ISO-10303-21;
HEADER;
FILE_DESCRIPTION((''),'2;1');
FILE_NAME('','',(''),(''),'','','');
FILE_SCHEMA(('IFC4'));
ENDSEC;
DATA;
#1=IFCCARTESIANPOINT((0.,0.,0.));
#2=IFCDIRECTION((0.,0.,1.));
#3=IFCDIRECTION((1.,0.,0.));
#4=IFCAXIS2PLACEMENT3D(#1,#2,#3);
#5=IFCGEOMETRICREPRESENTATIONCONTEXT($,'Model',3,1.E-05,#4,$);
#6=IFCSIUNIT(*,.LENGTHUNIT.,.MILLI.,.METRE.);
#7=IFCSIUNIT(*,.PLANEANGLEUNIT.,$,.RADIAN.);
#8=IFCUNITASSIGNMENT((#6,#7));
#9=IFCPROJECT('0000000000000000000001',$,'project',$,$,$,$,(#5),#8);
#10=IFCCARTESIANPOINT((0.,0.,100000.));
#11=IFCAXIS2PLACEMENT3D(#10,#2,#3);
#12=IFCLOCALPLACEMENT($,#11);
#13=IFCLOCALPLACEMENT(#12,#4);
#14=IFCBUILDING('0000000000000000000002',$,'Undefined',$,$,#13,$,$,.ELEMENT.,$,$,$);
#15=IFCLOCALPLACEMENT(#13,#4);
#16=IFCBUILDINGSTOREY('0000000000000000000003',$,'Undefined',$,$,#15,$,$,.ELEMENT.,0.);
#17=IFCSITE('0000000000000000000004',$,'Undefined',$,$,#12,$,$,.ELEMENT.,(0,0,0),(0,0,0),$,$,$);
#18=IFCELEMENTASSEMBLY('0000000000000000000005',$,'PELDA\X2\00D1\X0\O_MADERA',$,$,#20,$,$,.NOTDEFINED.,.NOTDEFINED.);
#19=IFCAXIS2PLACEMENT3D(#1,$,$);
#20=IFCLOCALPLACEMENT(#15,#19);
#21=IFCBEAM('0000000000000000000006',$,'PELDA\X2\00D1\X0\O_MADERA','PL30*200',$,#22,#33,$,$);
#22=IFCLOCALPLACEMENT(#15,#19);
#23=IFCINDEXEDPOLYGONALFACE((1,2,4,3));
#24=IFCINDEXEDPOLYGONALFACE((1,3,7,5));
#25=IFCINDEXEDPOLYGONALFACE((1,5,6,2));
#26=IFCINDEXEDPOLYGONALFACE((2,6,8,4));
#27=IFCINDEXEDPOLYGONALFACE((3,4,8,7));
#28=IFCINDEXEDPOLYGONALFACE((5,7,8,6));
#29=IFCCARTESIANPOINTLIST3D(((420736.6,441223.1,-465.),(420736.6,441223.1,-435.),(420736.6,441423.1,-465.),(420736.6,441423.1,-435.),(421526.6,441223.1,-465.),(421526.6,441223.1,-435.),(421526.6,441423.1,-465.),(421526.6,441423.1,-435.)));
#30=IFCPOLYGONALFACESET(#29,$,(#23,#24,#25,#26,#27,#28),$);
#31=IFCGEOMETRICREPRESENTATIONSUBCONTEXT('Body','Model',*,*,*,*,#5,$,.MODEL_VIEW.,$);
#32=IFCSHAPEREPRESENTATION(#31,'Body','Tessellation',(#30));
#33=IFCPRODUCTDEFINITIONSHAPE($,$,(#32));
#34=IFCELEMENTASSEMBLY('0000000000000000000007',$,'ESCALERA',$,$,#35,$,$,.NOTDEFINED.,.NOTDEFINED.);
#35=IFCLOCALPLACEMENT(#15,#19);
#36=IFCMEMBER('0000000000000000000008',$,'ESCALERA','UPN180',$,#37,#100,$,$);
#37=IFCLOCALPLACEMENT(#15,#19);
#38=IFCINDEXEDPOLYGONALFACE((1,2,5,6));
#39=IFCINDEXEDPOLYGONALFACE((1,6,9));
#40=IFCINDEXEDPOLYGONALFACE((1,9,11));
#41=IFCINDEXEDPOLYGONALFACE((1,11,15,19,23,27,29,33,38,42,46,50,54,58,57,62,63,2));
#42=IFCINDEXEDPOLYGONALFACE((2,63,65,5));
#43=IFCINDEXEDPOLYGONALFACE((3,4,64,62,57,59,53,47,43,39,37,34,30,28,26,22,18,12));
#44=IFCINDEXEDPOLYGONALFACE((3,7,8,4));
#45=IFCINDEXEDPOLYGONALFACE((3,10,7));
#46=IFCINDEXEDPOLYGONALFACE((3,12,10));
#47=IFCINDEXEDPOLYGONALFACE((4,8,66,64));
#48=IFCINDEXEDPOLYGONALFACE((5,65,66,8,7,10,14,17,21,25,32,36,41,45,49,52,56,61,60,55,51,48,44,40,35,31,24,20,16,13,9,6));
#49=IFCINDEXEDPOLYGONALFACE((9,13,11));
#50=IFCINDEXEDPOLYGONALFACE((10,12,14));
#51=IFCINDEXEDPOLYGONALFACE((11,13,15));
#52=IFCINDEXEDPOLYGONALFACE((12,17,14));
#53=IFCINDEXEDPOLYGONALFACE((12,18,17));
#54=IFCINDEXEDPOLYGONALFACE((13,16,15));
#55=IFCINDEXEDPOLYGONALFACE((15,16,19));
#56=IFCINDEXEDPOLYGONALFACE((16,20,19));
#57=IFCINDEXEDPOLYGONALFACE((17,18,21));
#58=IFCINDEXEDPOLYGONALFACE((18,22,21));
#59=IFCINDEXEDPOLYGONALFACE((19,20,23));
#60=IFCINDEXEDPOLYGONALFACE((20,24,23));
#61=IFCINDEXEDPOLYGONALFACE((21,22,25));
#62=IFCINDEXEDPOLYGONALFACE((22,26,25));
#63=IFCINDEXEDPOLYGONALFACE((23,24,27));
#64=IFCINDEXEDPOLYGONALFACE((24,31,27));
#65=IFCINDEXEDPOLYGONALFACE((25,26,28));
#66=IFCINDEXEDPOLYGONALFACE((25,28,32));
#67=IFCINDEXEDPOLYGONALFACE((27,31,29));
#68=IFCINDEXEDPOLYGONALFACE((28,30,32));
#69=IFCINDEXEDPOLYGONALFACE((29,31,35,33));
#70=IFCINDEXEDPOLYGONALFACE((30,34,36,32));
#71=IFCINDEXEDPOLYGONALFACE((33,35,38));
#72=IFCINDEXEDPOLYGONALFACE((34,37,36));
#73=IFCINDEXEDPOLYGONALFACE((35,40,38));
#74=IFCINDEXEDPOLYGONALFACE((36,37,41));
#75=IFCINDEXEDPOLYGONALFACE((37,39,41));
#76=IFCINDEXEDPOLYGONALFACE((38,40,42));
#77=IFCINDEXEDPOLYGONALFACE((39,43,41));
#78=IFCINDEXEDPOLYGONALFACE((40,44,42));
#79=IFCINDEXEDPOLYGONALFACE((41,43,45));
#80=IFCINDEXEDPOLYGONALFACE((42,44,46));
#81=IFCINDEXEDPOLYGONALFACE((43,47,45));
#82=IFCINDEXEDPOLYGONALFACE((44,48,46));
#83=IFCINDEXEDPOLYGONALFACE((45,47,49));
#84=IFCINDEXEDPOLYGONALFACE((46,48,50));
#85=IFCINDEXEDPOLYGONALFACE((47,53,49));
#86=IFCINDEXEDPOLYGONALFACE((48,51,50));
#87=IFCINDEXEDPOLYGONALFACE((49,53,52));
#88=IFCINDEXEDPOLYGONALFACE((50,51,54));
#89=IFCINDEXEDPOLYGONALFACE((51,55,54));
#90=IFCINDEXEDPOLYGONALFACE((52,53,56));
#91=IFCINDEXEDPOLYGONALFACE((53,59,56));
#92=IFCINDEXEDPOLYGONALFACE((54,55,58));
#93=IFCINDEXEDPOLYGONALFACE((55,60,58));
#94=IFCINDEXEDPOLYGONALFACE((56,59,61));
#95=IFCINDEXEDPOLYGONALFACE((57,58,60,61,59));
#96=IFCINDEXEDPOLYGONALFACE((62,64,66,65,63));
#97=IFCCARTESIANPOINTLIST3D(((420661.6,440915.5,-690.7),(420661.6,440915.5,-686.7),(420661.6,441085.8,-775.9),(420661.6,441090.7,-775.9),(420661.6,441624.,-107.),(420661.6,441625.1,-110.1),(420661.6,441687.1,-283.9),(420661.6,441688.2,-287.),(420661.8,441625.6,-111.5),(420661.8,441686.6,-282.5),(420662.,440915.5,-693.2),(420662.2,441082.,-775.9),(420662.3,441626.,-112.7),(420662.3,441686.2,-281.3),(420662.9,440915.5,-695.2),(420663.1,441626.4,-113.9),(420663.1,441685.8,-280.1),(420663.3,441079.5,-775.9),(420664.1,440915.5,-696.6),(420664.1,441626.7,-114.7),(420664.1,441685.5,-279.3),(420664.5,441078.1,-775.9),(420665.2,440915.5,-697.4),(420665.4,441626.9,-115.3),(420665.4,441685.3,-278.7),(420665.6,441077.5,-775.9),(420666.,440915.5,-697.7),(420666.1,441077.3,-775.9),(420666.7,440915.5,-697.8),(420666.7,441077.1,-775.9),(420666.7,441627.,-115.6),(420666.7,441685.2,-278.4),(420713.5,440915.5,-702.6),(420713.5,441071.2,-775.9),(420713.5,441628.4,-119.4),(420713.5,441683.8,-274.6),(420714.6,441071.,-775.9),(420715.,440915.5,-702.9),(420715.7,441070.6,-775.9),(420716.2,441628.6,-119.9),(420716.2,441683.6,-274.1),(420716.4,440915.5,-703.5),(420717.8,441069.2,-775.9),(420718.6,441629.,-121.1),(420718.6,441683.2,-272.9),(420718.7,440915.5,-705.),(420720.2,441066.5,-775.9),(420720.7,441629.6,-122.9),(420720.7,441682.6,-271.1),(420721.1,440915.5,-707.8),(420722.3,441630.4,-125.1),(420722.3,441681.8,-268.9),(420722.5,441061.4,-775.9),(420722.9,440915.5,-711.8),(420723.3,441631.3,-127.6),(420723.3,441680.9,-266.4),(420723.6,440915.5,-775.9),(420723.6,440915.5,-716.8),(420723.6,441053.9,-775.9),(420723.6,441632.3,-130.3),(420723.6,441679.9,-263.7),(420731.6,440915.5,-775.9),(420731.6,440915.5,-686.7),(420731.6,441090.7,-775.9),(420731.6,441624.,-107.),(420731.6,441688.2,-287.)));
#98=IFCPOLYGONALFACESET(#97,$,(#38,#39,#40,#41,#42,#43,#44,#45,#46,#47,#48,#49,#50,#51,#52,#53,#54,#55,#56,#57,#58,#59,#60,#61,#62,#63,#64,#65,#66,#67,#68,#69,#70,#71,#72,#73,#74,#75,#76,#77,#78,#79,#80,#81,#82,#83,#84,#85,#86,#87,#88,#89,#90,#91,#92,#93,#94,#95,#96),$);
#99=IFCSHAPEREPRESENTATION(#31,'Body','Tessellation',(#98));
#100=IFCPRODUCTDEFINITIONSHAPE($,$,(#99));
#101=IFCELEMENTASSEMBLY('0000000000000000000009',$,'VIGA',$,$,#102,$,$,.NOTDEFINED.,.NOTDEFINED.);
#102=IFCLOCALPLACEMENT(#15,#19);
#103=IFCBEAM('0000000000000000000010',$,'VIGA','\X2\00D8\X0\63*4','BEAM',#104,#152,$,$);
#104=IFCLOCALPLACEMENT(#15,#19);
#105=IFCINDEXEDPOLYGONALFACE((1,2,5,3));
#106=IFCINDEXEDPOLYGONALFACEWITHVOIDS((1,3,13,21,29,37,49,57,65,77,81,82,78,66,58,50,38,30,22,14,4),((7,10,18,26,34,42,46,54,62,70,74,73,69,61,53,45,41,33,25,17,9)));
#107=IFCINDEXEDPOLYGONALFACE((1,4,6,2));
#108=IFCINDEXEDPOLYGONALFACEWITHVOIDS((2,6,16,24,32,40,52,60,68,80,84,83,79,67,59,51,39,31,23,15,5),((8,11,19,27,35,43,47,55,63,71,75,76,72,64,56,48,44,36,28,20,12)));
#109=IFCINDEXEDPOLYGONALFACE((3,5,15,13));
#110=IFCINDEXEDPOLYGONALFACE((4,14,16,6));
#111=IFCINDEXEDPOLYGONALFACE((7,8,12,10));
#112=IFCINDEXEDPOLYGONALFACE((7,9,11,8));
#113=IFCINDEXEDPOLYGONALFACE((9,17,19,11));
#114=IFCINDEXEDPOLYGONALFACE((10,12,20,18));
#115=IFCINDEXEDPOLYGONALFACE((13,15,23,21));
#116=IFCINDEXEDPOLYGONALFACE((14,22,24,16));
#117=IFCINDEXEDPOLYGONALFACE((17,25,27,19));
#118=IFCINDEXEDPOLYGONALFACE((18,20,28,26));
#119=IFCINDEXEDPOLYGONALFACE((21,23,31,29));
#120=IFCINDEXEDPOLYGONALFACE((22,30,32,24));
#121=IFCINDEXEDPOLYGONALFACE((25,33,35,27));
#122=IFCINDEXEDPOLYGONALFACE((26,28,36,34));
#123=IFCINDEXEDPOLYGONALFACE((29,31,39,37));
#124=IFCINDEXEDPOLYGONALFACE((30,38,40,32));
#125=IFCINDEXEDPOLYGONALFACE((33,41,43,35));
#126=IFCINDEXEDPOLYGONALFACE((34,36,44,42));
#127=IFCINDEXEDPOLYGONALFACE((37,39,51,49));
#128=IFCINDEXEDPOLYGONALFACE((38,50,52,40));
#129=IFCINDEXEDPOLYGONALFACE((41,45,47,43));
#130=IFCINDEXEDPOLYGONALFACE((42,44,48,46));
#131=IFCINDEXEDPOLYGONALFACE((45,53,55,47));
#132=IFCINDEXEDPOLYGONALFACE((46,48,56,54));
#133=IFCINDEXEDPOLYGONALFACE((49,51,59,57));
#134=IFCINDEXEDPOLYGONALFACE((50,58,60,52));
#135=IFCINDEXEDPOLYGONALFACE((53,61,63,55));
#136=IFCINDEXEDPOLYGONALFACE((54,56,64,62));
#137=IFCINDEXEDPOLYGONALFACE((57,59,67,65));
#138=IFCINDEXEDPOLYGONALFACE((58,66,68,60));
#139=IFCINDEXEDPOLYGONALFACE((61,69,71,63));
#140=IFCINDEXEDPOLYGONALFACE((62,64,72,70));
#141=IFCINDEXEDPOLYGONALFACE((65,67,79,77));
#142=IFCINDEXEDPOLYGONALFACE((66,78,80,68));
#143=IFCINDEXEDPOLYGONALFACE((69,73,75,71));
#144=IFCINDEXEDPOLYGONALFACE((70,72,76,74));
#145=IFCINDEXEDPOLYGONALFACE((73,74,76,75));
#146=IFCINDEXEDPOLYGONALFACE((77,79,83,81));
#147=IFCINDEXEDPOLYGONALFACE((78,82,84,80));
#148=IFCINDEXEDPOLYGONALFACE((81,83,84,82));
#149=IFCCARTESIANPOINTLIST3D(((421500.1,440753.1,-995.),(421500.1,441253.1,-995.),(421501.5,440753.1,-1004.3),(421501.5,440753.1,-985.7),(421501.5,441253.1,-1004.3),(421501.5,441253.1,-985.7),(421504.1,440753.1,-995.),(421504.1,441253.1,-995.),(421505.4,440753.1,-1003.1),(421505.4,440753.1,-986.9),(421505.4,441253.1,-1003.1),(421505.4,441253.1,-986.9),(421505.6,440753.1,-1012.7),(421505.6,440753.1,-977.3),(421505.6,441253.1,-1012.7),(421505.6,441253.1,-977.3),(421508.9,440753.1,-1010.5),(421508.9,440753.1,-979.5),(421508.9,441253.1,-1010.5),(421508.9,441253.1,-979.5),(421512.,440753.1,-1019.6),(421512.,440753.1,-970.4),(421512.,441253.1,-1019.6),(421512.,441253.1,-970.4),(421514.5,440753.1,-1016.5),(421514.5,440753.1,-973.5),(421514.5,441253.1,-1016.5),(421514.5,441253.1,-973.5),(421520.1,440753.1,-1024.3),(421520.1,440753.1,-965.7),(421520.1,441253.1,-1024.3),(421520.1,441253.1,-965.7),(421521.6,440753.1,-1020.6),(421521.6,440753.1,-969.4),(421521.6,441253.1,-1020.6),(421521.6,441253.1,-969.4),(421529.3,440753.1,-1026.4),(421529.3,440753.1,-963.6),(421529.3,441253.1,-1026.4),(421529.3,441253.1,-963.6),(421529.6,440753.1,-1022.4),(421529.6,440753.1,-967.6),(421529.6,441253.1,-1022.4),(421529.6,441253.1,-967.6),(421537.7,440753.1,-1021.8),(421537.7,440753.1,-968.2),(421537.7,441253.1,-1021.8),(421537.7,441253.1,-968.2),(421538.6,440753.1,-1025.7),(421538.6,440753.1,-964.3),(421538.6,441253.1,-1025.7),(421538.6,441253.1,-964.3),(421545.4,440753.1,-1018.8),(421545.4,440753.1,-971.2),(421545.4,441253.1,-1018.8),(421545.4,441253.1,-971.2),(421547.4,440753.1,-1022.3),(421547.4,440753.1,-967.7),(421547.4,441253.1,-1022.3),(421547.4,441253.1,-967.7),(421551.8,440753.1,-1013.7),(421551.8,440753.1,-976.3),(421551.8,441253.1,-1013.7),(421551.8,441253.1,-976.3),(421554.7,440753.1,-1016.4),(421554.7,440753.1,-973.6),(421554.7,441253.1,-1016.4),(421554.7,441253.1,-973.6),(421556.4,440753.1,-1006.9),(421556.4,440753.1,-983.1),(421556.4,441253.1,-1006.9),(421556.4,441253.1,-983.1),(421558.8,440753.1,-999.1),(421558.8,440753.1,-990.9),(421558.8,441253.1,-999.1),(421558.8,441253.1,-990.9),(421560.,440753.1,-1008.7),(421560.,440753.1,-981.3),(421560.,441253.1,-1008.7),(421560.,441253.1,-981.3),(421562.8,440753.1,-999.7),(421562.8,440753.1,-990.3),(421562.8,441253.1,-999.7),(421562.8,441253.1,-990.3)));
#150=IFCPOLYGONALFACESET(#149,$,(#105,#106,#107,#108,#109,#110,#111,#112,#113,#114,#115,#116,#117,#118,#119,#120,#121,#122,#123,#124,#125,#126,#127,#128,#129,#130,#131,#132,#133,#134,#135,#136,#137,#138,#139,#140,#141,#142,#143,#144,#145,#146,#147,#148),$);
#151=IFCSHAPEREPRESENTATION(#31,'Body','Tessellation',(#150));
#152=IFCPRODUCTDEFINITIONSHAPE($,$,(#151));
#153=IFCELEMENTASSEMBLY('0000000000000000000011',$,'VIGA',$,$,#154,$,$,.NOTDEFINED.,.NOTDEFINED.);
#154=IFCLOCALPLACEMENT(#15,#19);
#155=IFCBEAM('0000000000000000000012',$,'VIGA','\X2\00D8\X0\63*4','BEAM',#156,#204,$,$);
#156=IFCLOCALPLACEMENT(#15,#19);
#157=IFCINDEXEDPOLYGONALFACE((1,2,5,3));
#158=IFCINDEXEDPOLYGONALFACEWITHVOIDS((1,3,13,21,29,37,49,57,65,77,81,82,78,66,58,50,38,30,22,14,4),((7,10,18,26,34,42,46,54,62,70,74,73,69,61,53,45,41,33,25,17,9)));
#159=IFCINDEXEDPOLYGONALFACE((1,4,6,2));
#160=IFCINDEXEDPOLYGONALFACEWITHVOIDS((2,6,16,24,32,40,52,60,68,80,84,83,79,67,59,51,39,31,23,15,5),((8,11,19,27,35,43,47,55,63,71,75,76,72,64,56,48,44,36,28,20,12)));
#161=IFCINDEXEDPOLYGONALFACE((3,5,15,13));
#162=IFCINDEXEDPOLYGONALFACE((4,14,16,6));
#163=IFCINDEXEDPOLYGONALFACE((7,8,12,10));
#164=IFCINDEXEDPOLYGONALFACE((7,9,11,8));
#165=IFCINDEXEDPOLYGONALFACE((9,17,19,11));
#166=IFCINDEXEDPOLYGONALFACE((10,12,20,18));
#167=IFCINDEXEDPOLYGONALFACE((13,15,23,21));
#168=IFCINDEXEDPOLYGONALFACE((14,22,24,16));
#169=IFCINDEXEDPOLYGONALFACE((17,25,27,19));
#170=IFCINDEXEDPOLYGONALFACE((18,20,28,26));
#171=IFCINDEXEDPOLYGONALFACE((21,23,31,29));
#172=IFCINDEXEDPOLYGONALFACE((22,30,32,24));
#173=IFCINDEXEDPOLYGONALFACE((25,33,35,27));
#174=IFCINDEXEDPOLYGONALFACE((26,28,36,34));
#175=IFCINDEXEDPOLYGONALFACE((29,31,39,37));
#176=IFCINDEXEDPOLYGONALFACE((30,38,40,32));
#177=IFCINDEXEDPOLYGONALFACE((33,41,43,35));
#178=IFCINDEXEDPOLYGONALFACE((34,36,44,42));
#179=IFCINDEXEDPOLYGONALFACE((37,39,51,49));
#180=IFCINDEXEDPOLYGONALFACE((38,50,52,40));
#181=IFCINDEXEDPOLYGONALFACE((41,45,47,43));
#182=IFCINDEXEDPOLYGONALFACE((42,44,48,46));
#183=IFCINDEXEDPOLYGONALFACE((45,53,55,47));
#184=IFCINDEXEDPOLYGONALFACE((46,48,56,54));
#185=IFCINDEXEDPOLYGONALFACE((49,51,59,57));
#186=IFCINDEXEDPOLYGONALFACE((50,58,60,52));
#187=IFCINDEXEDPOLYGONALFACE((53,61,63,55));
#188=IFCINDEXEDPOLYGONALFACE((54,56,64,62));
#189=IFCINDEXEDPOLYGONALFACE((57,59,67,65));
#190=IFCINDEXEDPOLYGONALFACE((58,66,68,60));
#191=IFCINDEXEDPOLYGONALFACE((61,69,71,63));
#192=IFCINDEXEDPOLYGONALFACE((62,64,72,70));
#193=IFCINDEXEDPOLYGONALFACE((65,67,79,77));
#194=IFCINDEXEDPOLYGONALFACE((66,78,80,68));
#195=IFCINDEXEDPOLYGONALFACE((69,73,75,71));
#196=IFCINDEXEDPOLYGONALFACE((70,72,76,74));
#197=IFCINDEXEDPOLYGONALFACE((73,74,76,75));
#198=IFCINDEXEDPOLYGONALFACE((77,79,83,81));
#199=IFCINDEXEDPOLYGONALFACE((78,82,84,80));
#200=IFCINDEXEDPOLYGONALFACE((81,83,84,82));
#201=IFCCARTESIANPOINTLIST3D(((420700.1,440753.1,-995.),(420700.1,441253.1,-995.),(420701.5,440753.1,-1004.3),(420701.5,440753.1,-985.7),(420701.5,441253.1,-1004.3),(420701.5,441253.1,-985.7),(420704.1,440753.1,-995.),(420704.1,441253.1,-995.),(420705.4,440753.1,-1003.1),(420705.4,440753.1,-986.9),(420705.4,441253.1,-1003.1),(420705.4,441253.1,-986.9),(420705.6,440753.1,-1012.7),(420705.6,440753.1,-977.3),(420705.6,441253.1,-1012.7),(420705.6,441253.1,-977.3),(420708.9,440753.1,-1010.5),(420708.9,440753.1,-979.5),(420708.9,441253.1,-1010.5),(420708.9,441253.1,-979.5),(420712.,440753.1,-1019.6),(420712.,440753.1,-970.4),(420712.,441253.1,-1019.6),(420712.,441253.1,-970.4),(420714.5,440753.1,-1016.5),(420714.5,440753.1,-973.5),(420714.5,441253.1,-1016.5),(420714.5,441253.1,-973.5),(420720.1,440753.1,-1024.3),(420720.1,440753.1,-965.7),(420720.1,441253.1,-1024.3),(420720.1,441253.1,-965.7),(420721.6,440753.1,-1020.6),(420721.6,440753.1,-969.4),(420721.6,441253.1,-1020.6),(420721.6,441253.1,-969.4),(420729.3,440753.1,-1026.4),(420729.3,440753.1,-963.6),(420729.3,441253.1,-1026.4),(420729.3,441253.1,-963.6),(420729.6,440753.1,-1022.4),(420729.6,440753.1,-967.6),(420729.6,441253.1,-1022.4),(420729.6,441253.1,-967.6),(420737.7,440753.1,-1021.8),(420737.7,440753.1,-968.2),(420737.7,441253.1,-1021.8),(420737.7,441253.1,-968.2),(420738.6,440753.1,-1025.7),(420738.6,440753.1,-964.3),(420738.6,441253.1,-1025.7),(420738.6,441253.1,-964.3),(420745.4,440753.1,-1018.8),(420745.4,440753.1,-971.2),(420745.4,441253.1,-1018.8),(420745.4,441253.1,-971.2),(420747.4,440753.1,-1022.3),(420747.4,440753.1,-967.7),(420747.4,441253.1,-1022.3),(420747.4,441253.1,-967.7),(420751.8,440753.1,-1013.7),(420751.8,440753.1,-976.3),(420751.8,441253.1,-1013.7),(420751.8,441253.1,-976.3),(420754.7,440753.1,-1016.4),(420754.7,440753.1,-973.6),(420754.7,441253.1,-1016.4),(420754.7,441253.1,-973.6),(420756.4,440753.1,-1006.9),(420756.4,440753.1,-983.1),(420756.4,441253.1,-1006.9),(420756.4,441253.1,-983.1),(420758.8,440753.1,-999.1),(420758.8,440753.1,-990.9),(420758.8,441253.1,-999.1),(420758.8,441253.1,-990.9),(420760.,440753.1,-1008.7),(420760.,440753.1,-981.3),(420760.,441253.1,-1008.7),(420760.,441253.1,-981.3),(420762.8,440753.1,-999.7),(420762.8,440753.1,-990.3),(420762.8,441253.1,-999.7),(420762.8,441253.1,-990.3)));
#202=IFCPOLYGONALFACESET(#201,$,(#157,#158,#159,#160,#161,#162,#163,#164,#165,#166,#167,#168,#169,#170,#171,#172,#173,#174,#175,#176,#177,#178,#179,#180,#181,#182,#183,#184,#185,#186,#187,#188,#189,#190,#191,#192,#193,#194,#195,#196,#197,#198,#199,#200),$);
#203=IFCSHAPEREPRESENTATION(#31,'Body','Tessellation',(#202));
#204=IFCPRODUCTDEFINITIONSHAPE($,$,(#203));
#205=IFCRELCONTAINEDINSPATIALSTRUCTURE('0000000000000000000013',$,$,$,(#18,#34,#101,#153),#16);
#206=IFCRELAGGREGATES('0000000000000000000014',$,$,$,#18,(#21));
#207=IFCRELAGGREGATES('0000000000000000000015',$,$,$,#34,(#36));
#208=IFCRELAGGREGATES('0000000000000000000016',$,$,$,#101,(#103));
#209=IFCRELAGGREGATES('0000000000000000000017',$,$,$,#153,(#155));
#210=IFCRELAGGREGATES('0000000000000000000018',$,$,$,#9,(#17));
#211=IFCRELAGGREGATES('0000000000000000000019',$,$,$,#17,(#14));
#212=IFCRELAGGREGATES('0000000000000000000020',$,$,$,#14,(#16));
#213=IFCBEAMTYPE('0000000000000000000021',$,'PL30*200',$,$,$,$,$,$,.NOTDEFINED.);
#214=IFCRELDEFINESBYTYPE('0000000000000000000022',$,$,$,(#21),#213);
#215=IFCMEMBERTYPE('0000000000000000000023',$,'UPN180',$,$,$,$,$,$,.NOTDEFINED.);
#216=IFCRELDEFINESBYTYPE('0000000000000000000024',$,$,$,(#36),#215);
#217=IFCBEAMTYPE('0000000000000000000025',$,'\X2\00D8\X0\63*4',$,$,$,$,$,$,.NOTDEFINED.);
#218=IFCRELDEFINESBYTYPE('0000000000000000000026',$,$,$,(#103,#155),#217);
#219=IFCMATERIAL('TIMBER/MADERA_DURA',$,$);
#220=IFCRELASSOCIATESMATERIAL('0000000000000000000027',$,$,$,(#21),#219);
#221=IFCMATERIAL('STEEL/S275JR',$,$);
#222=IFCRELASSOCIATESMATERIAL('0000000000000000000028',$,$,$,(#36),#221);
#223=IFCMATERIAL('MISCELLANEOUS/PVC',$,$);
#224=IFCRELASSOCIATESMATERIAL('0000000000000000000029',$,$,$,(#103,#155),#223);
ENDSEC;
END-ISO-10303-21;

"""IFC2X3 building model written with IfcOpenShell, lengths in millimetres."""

from ifc_helpers import new_model, si_unit, frame, origin_with_axes, origin_2d_with_axis, place, context, subcontext, project, spatial, rectangle, hollow_circle, u_section, extrude, clip, halfspace, material, type_object, element, aggregate, save


model = new_model("IFC2X3")

# Units and contexts
model_context = context("Model", 3, precision=1e-05, world=origin_with_axes())
body_context = subcontext(model_context, "Body", "Model", "MODEL_VIEW")
ifc_project = project(units=[si_unit("LENGTHUNIT", "METRE", prefix="MILLI"), si_unit("PLANEANGLEUNIT", "RADIAN")], contexts=[model_context])

# Site, building, storey
site_placement = place(None, frame((0.0, 0.0, 100000.0), z_axis=(0.0, 0.0, 1.0), x_axis=(1.0, 0.0, 0.0)))
site = spatial("IfcSite", under=ifc_project, at=site_placement, Name="Undefined", CompositionType="ELEMENT", RefLatitude=(0, 0, 0), RefLongitude=(0, 0, 0))
building_placement = place(site_placement, origin_with_axes())
building = spatial("IfcBuilding", under=site, at=building_placement, Name="Undefined", CompositionType="ELEMENT")
storey_placement = place(building_placement, origin_with_axes())
storey = spatial("IfcBuildingStorey", under=building, at=storey_placement, Name="Undefined", CompositionType="ELEMENT", Elevation=0.0)

# Shared definitions
ifc_material_1 = material(Name="STEEL/S275JR")

# Element assembly, beam
ifc_material_2 = material(Name="TIMBER/MADERA_DURA")
beam_type_1 = type_object("IfcBeamType", Name="PL30*200", PredefinedType="NOTDEFINED")
assembly_1_placement = place(storey_placement, origin_with_axes())
assembly_1 = element("IfcElementAssembly", 1, at=assembly_1_placement, inside=storey, Name="PELDAÑO_MADERA", AssemblyPlace="NOTDEFINED", PredefinedType="NOTDEFINED")
beam_1_placement = place(assembly_1_placement, frame((421526.6, 441323.1, -450.0), z_axis=(0.000001, 1.0, 0.0), x_axis=(-1.0, 0.000001, 0.0)))
beam_1 = element("IfcBeam", 2, at=beam_1_placement, type_object=beam_type_1, material=ifc_material_2, Name="PELDAÑO_MADERA", Description="PL30*200", context=body_context, shape_type="SweptSolid", body=[
    extrude(rectangle(XDim=30.0, YDim=200.0, at=origin_2d_with_axis()), frame((790.0, 0.0, 0.0), z_axis=(-1.0, 0.0, 0.0), x_axis=(0.0, -1.0, 0.0)), (0.0, 0.0, 1.0), 790.0),
])
aggregate(assembly_1, [beam_1])

# Element assembly, member
assembly_2_placement = place(storey_placement, origin_with_axes())
assembly_2 = element("IfcElementAssembly", 3, at=assembly_2_placement, inside=storey, Name="ESCALERA", AssemblyPlace="NOTDEFINED", PredefinedType="NOTDEFINED")
member_type_1 = type_object("IfcMemberType", Name="UPN180", PredefinedType="NOTDEFINED")
member_1_placement = place(assembly_2_placement, frame((420696.6, 441681.0, -176.7), z_axis=(-0.000001, -0.633238, 0.773957), x_axis=(-0.000001, -0.773957, -0.633238)))
member_1 = element("IfcMember", 4, at=member_1_placement, type_object=member_type_1, material=ifc_material_1, Name="ESCALERA", Description="UPN180", context=body_context, shape_type="Clipping", body=[
    clip(clip(clip(extrude(u_section(Depth=180.0, FlangeWidth=70.0, WebThickness=8.0, FlangeThickness=11.0, FilletRadius=11.0, EdgeRadius=5.5, FlangeSlope=0.07983, at=origin_2d_with_axis()), frame((1054.8, 0.0, 0.0), z_axis=(-1.0, 0.0, 0.0), x_axis=(0.0, -1.0, 0.0)), (0.0, 0.0, 1.0), 1131.3), halfspace(frame((1062.7, -35.0, -90.0), z_axis=(0.773957, 0.0, 0.633238), x_axis=(-0.633238, 0.0, 0.773957)), False)), halfspace(frame((894.5, 1035.0, -42.3), z_axis=(-0.633238, 0.0, 0.773957), x_axis=(0.773957, 0.0, 0.633238)), True)), halfspace(frame((0.0, -35.0, 90.0), z_axis=(-0.941795, 0.0, -0.336186), x_axis=(0.0, -1.0, 0.0)), False)),
])
aggregate(assembly_2, [member_1])

# Element assemblies, beams
assembly_3_placement = place(storey_placement, origin_with_axes())
assembly_3 = element("IfcElementAssembly", 5, at=assembly_3_placement, inside=storey, Name="VIGA", AssemblyPlace="NOTDEFINED", PredefinedType="NOTDEFINED")
ifc_material_3 = material(Name="MISCELLANEOUS/PVC")
beam_type_2 = type_object("IfcBeamType", Name="Ø63*4", PredefinedType="NOTDEFINED")
beam_2_placement = place(assembly_3_placement, frame((421531.6, 441253.1, -995.0), z_axis=(0.0, 0.0, 1.0), x_axis=(0.0, -1.0, 0.0)))
beam_2 = element("IfcBeam", 6, at=beam_2_placement, type_object=beam_type_2, material=ifc_material_3, Name="VIGA", Description="Ø63*4", ObjectType="BEAM", context=body_context, shape_type="SweptSolid", body=[
    extrude(hollow_circle(Radius=31.5, WallThickness=4.0, at=origin_2d_with_axis()), frame((500.0, 0.0, 0.0), z_axis=(-1.0, 0.0, 0.0), x_axis=(0.0, -1.0, 0.0)), (0.0, 0.0, 1.0), 500.0),
])
aggregate(assembly_3, [beam_2])
assembly_4_placement = place(storey_placement, origin_with_axes())
assembly_4 = element("IfcElementAssembly", 7, at=assembly_4_placement, inside=storey, Name="VIGA", AssemblyPlace="NOTDEFINED", PredefinedType="NOTDEFINED")
beam_3_placement = place(assembly_4_placement, frame((420731.6, 441253.1, -995.0), z_axis=(0.0, 0.0, 1.0), x_axis=(0.0, -1.0, 0.0)))
beam_3 = element("IfcBeam", 8, at=beam_3_placement, type_object=beam_type_2, material=ifc_material_3, Name="VIGA", Description="Ø63*4", ObjectType="BEAM", context=body_context, shape_type="SweptSolid", body=[
    extrude(hollow_circle(Radius=31.5, WallThickness=4.0, at=origin_2d_with_axis()), frame((500.0, 0.0, 0.0), z_axis=(-1.0, 0.0, 0.0), x_axis=(0.0, -1.0, 0.0)), (0.0, 0.0, 1.0), 500.0),
])
aggregate(assembly_4, [beam_3])

save(model, "model.ifc")
